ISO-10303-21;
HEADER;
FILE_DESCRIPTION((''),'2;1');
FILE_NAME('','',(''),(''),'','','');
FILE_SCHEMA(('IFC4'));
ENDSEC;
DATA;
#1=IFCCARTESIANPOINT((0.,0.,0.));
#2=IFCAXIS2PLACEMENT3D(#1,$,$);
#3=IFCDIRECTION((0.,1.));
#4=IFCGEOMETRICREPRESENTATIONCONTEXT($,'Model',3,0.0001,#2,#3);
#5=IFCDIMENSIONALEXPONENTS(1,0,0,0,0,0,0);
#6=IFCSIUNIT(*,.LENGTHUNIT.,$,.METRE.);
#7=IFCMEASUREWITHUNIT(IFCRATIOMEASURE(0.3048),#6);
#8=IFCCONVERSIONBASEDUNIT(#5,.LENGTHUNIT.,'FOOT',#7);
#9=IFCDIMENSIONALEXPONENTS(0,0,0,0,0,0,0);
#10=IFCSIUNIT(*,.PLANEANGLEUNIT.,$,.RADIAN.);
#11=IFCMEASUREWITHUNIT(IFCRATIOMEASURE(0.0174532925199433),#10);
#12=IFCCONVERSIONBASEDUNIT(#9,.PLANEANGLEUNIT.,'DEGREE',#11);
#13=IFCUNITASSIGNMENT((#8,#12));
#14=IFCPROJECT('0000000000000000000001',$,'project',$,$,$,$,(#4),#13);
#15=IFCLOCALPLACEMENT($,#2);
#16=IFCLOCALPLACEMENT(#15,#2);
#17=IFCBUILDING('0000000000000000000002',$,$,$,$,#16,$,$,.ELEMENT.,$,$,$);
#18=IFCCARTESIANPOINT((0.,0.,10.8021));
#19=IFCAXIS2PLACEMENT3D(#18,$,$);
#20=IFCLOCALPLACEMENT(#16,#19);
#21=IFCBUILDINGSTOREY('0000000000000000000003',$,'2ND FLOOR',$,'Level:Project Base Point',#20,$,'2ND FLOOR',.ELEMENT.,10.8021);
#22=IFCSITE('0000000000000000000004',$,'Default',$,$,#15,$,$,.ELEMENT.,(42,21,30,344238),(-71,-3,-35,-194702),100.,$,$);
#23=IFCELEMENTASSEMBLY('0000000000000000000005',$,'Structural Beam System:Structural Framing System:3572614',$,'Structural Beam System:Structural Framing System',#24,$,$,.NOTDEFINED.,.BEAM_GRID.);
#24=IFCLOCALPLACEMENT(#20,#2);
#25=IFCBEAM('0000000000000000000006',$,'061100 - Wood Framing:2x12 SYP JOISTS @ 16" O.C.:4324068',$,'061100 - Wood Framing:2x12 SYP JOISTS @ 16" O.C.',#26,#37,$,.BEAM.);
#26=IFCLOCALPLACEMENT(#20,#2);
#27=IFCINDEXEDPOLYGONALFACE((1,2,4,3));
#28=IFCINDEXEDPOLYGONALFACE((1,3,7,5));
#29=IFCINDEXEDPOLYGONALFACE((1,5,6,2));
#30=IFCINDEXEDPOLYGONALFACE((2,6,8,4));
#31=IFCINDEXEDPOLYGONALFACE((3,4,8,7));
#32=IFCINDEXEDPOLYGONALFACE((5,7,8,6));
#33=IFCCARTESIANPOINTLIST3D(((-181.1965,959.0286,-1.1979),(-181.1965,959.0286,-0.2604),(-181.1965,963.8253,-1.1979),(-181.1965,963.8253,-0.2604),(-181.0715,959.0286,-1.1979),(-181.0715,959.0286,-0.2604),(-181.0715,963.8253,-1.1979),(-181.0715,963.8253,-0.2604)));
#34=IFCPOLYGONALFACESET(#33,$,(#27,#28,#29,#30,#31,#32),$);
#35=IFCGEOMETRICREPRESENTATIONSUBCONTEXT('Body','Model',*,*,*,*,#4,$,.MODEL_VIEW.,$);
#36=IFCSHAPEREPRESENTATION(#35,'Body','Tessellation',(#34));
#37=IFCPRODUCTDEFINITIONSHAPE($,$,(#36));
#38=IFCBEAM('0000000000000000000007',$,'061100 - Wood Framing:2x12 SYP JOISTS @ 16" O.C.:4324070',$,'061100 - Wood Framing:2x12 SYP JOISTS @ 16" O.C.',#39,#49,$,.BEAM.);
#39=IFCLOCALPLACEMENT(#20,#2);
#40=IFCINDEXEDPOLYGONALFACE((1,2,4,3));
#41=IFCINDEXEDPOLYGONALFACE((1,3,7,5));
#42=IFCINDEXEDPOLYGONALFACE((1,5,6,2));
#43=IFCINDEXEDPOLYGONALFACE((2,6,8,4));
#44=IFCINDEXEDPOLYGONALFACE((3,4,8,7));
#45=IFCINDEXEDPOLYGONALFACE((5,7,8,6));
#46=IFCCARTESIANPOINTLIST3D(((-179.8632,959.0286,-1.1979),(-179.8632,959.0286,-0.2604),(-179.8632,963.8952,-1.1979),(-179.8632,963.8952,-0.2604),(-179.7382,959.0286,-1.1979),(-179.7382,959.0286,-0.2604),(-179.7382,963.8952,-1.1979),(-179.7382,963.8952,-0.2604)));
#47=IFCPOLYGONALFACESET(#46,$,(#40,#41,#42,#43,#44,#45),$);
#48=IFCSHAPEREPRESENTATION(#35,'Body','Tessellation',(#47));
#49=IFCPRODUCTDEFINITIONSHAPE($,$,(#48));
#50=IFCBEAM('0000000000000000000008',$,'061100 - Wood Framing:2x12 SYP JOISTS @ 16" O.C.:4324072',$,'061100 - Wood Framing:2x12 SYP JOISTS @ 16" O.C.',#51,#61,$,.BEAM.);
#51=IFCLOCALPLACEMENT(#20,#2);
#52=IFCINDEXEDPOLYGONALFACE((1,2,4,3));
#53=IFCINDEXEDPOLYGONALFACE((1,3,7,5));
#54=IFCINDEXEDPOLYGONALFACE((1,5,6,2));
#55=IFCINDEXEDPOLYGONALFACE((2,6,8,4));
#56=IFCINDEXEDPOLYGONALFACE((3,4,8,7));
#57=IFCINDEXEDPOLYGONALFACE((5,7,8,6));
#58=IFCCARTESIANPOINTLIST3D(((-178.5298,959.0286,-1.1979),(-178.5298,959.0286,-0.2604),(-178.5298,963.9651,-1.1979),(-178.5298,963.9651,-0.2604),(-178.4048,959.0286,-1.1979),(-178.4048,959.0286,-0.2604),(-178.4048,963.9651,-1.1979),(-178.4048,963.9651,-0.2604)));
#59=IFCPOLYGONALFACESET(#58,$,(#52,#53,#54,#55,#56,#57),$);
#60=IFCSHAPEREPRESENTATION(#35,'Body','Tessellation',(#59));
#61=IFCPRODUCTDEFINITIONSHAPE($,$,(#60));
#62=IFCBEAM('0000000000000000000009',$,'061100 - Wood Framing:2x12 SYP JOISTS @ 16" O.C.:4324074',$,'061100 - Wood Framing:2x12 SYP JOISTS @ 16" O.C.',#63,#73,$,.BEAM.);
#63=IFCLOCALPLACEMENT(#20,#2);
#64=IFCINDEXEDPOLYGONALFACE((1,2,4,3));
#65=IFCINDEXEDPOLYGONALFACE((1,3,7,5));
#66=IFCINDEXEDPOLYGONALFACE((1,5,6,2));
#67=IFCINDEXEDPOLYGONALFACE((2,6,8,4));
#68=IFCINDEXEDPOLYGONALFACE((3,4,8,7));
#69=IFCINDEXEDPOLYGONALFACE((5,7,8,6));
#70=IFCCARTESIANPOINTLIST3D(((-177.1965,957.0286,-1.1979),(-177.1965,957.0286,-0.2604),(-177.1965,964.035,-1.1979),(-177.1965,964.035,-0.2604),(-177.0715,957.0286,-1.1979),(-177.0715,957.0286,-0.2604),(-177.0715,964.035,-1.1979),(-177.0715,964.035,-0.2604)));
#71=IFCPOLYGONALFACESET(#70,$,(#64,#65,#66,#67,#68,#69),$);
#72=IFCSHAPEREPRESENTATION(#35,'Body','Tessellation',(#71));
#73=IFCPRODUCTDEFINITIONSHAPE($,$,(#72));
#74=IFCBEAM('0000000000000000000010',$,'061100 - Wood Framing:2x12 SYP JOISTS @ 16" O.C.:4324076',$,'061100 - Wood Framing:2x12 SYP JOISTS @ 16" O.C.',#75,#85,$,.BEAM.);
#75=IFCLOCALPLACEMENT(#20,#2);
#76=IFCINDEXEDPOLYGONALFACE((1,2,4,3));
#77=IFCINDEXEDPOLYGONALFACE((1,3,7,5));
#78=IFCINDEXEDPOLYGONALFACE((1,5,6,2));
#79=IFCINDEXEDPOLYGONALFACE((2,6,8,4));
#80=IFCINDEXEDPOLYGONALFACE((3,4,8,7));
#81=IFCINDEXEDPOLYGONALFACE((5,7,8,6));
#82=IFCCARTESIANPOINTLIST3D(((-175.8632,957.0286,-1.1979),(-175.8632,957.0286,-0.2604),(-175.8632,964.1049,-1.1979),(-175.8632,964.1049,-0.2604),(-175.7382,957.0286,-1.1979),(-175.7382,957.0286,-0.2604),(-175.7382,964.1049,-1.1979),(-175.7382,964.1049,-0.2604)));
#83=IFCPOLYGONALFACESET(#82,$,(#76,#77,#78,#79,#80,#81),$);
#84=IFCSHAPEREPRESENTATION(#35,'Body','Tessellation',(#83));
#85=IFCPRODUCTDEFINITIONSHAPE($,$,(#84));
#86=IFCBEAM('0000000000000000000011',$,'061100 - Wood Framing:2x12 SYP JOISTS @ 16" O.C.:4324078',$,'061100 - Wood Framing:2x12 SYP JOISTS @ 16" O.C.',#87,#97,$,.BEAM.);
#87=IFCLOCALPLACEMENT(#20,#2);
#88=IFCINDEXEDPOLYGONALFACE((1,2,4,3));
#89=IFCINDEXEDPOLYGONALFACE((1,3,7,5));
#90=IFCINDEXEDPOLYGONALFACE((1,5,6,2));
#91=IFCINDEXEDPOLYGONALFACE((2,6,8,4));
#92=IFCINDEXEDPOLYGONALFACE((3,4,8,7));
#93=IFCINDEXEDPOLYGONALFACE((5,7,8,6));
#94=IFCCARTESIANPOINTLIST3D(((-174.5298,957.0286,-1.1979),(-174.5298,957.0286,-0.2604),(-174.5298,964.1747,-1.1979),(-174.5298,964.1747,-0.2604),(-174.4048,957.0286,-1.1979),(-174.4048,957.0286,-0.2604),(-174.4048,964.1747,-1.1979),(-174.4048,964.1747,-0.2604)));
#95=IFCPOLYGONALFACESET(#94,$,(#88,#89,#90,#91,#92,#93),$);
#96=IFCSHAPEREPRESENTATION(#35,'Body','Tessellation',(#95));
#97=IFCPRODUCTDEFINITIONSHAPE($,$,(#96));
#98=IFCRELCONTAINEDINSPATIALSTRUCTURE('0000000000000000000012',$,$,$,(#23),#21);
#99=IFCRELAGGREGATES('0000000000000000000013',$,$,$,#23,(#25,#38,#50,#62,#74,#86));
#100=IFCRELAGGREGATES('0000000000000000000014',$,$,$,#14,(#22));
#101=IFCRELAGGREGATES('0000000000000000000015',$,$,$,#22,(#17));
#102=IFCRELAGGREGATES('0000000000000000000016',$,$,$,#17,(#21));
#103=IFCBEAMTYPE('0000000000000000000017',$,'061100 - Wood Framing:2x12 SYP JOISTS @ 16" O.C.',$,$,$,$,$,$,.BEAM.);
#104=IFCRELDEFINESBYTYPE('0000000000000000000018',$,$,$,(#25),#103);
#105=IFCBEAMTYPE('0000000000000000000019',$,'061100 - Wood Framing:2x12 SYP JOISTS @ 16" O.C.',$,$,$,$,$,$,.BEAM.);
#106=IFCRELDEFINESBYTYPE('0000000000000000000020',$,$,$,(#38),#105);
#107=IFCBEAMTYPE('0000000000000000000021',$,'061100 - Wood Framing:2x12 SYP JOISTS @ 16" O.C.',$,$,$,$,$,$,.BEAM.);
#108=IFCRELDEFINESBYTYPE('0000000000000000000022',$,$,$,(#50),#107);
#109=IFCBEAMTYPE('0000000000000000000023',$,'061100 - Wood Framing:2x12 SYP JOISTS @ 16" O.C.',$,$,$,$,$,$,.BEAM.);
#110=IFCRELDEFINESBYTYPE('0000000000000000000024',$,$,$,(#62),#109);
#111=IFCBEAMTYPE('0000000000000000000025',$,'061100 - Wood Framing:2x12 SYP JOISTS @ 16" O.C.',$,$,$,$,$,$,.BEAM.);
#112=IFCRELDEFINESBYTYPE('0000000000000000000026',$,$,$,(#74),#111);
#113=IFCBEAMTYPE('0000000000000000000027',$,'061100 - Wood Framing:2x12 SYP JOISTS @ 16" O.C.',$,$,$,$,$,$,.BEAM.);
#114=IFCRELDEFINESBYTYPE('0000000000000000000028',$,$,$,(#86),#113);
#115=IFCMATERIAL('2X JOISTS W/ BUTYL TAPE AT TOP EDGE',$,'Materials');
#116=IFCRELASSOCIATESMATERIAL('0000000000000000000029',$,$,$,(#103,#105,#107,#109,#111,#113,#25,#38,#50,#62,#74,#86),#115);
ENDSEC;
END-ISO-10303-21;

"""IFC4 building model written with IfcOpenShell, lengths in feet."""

from ifc_helpers import new_model, entity, si_unit, converted_unit, direction, frame, origin, origin_2d_with_axis, place, context, subcontext, project, spatial, rectangle, extrude, source, transform, mapped, material, material_profile, profile_set, profile_usage, type_object, type_shapes, element, aggregate, save


model = new_model("IFC4")

# Units and contexts
model_context = context("Model", 3, precision=0.0001, world=origin(), true_north=direction((0.0, 1.0)))
body_context = subcontext(model_context, "Body", "Model", "MODEL_VIEW")
ifc_project = project(units=[converted_unit("LENGTHUNIT", "FOOT", entity("IfcRatioMeasure", 0.3048), si_unit("LENGTHUNIT", "METRE"), dimensions=[1, 0, 0, 0, 0, 0, 0]), converted_unit("PLANEANGLEUNIT", "DEGREE", entity("IfcRatioMeasure", 0.0174532925199433), si_unit("PLANEANGLEUNIT", "RADIAN"), dimensions=[0, 0, 0, 0, 0, 0, 0])], contexts=[model_context])

# Site, building, storey
site_placement = place(None, origin())
site = spatial("IfcSite", under=ifc_project, at=site_placement, Name="Default", CompositionType="ELEMENT", RefLatitude=(42, 21, 30, 344238), RefLongitude=(-71, -3, -35, -194702), RefElevation=100.0)
building_placement = place(site_placement, origin())
building = spatial("IfcBuilding", under=site, at=building_placement, CompositionType="ELEMENT")
storey_placement = place(building_placement, frame((0.0, 0.0, 10.8021)))
storey = spatial("IfcBuildingStorey", under=building, at=storey_placement, Name="2ND FLOOR", ObjectType="Level:Project Base Point", LongName="2ND FLOOR", CompositionType="ELEMENT", Elevation=10.8021)

# Element assembly, beams
assembly_1_placement = place(storey_placement, origin())
assembly_1 = element("IfcElementAssembly", 1, at=assembly_1_placement, inside=storey, Name="Structural Beam System:Structural Framing System:3572614", ObjectType="Structural Beam System:Structural Framing System", AssemblyPlace="NOTDEFINED", PredefinedType="BEAM_GRID")
ifc_material_1 = material(Name="2X JOISTS W/ BUTYL TAPE AT TOP EDGE", Category="Materials")
ifc_material_profile_1 = material_profile(ifc_material_1, rectangle(XDim=0.9375, YDim=0.125, at=origin_2d_with_axis()), Name="2x12 SYP JOISTS @ 16\" O.C.")
ifc_profile_set_1 = profile_set([ifc_material_profile_1], Name="2x12 SYP JOISTS @ 16\" O.C.")
ifc_profile_usage_1 = profile_usage(ifc_profile_set_1, cardinal=8)
beam_type_1 = type_object("IfcBeamType", Name="061100 - Wood Framing:2x12 SYP JOISTS @ 16\" O.C.", PredefinedType="BEAM", material=ifc_profile_set_1)
shared_shape_1 = source(origin(), body_context, "Body", "SweptSolid", [
    extrude(rectangle(XDim=0.9375, YDim=0.125, at=origin_2d_with_axis()), frame((-2.3984, 0.0, 0.0), z_axis=(1.0, 0.0, 0.0), x_axis=(0.0, 0.0, -1.0)), (0.0, 0.0, 1.0), 4.7967),
])
type_shapes(beam_type_1, [shared_shape_1])
beam_1_placement = place(assembly_1_placement, frame((-181.134, 961.427, -0.7292), z_axis=(0.0, 0.0, 1.0), x_axis=(0.0, 1.0, 0.0)))
beam_1 = element("IfcBeam", 2, at=beam_1_placement, type_object=beam_type_1, material=ifc_profile_usage_1, Name="061100 - Wood Framing:2x12 SYP JOISTS @ 16\" O.C.:4324068", ObjectType="061100 - Wood Framing:2x12 SYP JOISTS @ 16\" O.C.", PredefinedType="BEAM", context=body_context, shape_type="MappedRepresentation", body=[
    mapped(shared_shape_1, transform((0.0, 0.0, 0.0), scale=1.0)),
])
ifc_profile_usage_2 = profile_usage(ifc_profile_set_1, cardinal=8)
beam_type_2 = type_object("IfcBeamType", Name="061100 - Wood Framing:2x12 SYP JOISTS @ 16\" O.C.", PredefinedType="BEAM", material=ifc_profile_set_1)
shared_shape_2 = source(origin(), body_context, "Body", "SweptSolid", [
    extrude(rectangle(XDim=0.9375, YDim=0.125, at=origin_2d_with_axis()), frame((-2.4333, 0.0, 0.0), z_axis=(1.0, 0.0, 0.0), x_axis=(0.0, 0.0, -1.0)), (0.0, 0.0, 1.0), 4.8666),
])
type_shapes(beam_type_2, [shared_shape_2])
beam_2_placement = place(assembly_1_placement, frame((-179.8007, 961.4619, -0.7292), z_axis=(0.0, 0.0, 1.0), x_axis=(0.0, 1.0, 0.0)))
beam_2 = element("IfcBeam", 3, at=beam_2_placement, type_object=beam_type_2, material=ifc_profile_usage_2, Name="061100 - Wood Framing:2x12 SYP JOISTS @ 16\" O.C.:4324070", ObjectType="061100 - Wood Framing:2x12 SYP JOISTS @ 16\" O.C.", PredefinedType="BEAM", context=body_context, shape_type="MappedRepresentation", body=[
    mapped(shared_shape_2, transform((0.0, 0.0, 0.0), scale=1.0)),
])
ifc_profile_usage_3 = profile_usage(ifc_profile_set_1, cardinal=8)
beam_type_3 = type_object("IfcBeamType", Name="061100 - Wood Framing:2x12 SYP JOISTS @ 16\" O.C.", PredefinedType="BEAM", material=ifc_profile_set_1)
shared_shape_3 = source(origin(), body_context, "Body", "SweptSolid", [
    extrude(rectangle(XDim=0.9375, YDim=0.125, at=origin_2d_with_axis()), frame((-2.4682, 0.0, 0.0), z_axis=(1.0, 0.0, 0.0), x_axis=(0.0, 0.0, -1.0)), (0.0, 0.0, 1.0), 4.9365),
])
type_shapes(beam_type_3, [shared_shape_3])
beam_3_placement = place(assembly_1_placement, frame((-178.4673, 961.4968, -0.7292), z_axis=(0.0, 0.0, 1.0), x_axis=(0.0, 1.0, 0.0)))
beam_3 = element("IfcBeam", 4, at=beam_3_placement, type_object=beam_type_3, material=ifc_profile_usage_3, Name="061100 - Wood Framing:2x12 SYP JOISTS @ 16\" O.C.:4324072", ObjectType="061100 - Wood Framing:2x12 SYP JOISTS @ 16\" O.C.", PredefinedType="BEAM", context=body_context, shape_type="MappedRepresentation", body=[
    mapped(shared_shape_3, transform((0.0, 0.0, 0.0), scale=1.0)),
])
ifc_profile_usage_4 = profile_usage(ifc_profile_set_1, cardinal=8)
beam_type_4 = type_object("IfcBeamType", Name="061100 - Wood Framing:2x12 SYP JOISTS @ 16\" O.C.", PredefinedType="BEAM", material=ifc_profile_set_1)
shared_shape_4 = source(origin(), body_context, "Body", "SweptSolid", [
    extrude(rectangle(XDim=0.9375, YDim=0.125, at=origin_2d_with_axis()), frame((-3.5032, 0.0, 0.0), z_axis=(1.0, 0.0, 0.0), x_axis=(0.0, 0.0, -1.0)), (0.0, 0.0, 1.0), 7.0064),
])
type_shapes(beam_type_4, [shared_shape_4])
beam_4_placement = place(assembly_1_placement, frame((-177.134, 960.5318, -0.7292), z_axis=(0.0, 0.0, 1.0), x_axis=(0.0, 1.0, 0.0)))
beam_4 = element("IfcBeam", 5, at=beam_4_placement, type_object=beam_type_4, material=ifc_profile_usage_4, Name="061100 - Wood Framing:2x12 SYP JOISTS @ 16\" O.C.:4324074", ObjectType="061100 - Wood Framing:2x12 SYP JOISTS @ 16\" O.C.", PredefinedType="BEAM", context=body_context, shape_type="MappedRepresentation", body=[
    mapped(shared_shape_4, transform((0.0, 0.0, 0.0), scale=1.0)),
])
ifc_profile_usage_5 = profile_usage(ifc_profile_set_1, cardinal=8)
beam_type_5 = type_object("IfcBeamType", Name="061100 - Wood Framing:2x12 SYP JOISTS @ 16\" O.C.", PredefinedType="BEAM", material=ifc_profile_set_1)
shared_shape_5 = source(origin(), body_context, "Body", "SweptSolid", [
    extrude(rectangle(XDim=0.9375, YDim=0.125, at=origin_2d_with_axis()), frame((-3.5381, 0.0, 0.0), z_axis=(1.0, 0.0, 0.0), x_axis=(0.0, 0.0, -1.0)), (0.0, 0.0, 1.0), 7.0762),
])
type_shapes(beam_type_5, [shared_shape_5])
beam_5_placement = place(assembly_1_placement, frame((-175.8007, 960.5667, -0.7292), z_axis=(0.0, 0.0, 1.0), x_axis=(0.0, 1.0, 0.0)))
beam_5 = element("IfcBeam", 6, at=beam_5_placement, type_object=beam_type_5, material=ifc_profile_usage_5, Name="061100 - Wood Framing:2x12 SYP JOISTS @ 16\" O.C.:4324076", ObjectType="061100 - Wood Framing:2x12 SYP JOISTS @ 16\" O.C.", PredefinedType="BEAM", context=body_context, shape_type="MappedRepresentation", body=[
    mapped(shared_shape_5, transform((0.0, 0.0, 0.0), scale=1.0)),
])
ifc_profile_usage_6 = profile_usage(ifc_profile_set_1, cardinal=8)
beam_type_6 = type_object("IfcBeamType", Name="061100 - Wood Framing:2x12 SYP JOISTS @ 16\" O.C.", PredefinedType="BEAM", material=ifc_profile_set_1)
shared_shape_6 = source(origin(), body_context, "Body", "SweptSolid", [
    extrude(rectangle(XDim=0.9375, YDim=0.125, at=origin_2d_with_axis()), frame((-3.5731, 0.0, 0.0), z_axis=(1.0, 0.0, 0.0), x_axis=(0.0, 0.0, -1.0)), (0.0, 0.0, 1.0), 7.1461),
])
type_shapes(beam_type_6, [shared_shape_6])
beam_6_placement = place(assembly_1_placement, frame((-174.4673, 960.6017, -0.7292), z_axis=(0.0, 0.0, 1.0), x_axis=(0.0, 1.0, 0.0)))
beam_6 = element("IfcBeam", 7, at=beam_6_placement, type_object=beam_type_6, material=ifc_profile_usage_6, Name="061100 - Wood Framing:2x12 SYP JOISTS @ 16\" O.C.:4324078", ObjectType="061100 - Wood Framing:2x12 SYP JOISTS @ 16\" O.C.", PredefinedType="BEAM", context=body_context, shape_type="MappedRepresentation", body=[
    mapped(shared_shape_6, transform((0.0, 0.0, 0.0), scale=1.0)),
])
aggregate(assembly_1, [beam_1, beam_2, beam_3, beam_4, beam_5, beam_6])

save(model, "model.ifc")
